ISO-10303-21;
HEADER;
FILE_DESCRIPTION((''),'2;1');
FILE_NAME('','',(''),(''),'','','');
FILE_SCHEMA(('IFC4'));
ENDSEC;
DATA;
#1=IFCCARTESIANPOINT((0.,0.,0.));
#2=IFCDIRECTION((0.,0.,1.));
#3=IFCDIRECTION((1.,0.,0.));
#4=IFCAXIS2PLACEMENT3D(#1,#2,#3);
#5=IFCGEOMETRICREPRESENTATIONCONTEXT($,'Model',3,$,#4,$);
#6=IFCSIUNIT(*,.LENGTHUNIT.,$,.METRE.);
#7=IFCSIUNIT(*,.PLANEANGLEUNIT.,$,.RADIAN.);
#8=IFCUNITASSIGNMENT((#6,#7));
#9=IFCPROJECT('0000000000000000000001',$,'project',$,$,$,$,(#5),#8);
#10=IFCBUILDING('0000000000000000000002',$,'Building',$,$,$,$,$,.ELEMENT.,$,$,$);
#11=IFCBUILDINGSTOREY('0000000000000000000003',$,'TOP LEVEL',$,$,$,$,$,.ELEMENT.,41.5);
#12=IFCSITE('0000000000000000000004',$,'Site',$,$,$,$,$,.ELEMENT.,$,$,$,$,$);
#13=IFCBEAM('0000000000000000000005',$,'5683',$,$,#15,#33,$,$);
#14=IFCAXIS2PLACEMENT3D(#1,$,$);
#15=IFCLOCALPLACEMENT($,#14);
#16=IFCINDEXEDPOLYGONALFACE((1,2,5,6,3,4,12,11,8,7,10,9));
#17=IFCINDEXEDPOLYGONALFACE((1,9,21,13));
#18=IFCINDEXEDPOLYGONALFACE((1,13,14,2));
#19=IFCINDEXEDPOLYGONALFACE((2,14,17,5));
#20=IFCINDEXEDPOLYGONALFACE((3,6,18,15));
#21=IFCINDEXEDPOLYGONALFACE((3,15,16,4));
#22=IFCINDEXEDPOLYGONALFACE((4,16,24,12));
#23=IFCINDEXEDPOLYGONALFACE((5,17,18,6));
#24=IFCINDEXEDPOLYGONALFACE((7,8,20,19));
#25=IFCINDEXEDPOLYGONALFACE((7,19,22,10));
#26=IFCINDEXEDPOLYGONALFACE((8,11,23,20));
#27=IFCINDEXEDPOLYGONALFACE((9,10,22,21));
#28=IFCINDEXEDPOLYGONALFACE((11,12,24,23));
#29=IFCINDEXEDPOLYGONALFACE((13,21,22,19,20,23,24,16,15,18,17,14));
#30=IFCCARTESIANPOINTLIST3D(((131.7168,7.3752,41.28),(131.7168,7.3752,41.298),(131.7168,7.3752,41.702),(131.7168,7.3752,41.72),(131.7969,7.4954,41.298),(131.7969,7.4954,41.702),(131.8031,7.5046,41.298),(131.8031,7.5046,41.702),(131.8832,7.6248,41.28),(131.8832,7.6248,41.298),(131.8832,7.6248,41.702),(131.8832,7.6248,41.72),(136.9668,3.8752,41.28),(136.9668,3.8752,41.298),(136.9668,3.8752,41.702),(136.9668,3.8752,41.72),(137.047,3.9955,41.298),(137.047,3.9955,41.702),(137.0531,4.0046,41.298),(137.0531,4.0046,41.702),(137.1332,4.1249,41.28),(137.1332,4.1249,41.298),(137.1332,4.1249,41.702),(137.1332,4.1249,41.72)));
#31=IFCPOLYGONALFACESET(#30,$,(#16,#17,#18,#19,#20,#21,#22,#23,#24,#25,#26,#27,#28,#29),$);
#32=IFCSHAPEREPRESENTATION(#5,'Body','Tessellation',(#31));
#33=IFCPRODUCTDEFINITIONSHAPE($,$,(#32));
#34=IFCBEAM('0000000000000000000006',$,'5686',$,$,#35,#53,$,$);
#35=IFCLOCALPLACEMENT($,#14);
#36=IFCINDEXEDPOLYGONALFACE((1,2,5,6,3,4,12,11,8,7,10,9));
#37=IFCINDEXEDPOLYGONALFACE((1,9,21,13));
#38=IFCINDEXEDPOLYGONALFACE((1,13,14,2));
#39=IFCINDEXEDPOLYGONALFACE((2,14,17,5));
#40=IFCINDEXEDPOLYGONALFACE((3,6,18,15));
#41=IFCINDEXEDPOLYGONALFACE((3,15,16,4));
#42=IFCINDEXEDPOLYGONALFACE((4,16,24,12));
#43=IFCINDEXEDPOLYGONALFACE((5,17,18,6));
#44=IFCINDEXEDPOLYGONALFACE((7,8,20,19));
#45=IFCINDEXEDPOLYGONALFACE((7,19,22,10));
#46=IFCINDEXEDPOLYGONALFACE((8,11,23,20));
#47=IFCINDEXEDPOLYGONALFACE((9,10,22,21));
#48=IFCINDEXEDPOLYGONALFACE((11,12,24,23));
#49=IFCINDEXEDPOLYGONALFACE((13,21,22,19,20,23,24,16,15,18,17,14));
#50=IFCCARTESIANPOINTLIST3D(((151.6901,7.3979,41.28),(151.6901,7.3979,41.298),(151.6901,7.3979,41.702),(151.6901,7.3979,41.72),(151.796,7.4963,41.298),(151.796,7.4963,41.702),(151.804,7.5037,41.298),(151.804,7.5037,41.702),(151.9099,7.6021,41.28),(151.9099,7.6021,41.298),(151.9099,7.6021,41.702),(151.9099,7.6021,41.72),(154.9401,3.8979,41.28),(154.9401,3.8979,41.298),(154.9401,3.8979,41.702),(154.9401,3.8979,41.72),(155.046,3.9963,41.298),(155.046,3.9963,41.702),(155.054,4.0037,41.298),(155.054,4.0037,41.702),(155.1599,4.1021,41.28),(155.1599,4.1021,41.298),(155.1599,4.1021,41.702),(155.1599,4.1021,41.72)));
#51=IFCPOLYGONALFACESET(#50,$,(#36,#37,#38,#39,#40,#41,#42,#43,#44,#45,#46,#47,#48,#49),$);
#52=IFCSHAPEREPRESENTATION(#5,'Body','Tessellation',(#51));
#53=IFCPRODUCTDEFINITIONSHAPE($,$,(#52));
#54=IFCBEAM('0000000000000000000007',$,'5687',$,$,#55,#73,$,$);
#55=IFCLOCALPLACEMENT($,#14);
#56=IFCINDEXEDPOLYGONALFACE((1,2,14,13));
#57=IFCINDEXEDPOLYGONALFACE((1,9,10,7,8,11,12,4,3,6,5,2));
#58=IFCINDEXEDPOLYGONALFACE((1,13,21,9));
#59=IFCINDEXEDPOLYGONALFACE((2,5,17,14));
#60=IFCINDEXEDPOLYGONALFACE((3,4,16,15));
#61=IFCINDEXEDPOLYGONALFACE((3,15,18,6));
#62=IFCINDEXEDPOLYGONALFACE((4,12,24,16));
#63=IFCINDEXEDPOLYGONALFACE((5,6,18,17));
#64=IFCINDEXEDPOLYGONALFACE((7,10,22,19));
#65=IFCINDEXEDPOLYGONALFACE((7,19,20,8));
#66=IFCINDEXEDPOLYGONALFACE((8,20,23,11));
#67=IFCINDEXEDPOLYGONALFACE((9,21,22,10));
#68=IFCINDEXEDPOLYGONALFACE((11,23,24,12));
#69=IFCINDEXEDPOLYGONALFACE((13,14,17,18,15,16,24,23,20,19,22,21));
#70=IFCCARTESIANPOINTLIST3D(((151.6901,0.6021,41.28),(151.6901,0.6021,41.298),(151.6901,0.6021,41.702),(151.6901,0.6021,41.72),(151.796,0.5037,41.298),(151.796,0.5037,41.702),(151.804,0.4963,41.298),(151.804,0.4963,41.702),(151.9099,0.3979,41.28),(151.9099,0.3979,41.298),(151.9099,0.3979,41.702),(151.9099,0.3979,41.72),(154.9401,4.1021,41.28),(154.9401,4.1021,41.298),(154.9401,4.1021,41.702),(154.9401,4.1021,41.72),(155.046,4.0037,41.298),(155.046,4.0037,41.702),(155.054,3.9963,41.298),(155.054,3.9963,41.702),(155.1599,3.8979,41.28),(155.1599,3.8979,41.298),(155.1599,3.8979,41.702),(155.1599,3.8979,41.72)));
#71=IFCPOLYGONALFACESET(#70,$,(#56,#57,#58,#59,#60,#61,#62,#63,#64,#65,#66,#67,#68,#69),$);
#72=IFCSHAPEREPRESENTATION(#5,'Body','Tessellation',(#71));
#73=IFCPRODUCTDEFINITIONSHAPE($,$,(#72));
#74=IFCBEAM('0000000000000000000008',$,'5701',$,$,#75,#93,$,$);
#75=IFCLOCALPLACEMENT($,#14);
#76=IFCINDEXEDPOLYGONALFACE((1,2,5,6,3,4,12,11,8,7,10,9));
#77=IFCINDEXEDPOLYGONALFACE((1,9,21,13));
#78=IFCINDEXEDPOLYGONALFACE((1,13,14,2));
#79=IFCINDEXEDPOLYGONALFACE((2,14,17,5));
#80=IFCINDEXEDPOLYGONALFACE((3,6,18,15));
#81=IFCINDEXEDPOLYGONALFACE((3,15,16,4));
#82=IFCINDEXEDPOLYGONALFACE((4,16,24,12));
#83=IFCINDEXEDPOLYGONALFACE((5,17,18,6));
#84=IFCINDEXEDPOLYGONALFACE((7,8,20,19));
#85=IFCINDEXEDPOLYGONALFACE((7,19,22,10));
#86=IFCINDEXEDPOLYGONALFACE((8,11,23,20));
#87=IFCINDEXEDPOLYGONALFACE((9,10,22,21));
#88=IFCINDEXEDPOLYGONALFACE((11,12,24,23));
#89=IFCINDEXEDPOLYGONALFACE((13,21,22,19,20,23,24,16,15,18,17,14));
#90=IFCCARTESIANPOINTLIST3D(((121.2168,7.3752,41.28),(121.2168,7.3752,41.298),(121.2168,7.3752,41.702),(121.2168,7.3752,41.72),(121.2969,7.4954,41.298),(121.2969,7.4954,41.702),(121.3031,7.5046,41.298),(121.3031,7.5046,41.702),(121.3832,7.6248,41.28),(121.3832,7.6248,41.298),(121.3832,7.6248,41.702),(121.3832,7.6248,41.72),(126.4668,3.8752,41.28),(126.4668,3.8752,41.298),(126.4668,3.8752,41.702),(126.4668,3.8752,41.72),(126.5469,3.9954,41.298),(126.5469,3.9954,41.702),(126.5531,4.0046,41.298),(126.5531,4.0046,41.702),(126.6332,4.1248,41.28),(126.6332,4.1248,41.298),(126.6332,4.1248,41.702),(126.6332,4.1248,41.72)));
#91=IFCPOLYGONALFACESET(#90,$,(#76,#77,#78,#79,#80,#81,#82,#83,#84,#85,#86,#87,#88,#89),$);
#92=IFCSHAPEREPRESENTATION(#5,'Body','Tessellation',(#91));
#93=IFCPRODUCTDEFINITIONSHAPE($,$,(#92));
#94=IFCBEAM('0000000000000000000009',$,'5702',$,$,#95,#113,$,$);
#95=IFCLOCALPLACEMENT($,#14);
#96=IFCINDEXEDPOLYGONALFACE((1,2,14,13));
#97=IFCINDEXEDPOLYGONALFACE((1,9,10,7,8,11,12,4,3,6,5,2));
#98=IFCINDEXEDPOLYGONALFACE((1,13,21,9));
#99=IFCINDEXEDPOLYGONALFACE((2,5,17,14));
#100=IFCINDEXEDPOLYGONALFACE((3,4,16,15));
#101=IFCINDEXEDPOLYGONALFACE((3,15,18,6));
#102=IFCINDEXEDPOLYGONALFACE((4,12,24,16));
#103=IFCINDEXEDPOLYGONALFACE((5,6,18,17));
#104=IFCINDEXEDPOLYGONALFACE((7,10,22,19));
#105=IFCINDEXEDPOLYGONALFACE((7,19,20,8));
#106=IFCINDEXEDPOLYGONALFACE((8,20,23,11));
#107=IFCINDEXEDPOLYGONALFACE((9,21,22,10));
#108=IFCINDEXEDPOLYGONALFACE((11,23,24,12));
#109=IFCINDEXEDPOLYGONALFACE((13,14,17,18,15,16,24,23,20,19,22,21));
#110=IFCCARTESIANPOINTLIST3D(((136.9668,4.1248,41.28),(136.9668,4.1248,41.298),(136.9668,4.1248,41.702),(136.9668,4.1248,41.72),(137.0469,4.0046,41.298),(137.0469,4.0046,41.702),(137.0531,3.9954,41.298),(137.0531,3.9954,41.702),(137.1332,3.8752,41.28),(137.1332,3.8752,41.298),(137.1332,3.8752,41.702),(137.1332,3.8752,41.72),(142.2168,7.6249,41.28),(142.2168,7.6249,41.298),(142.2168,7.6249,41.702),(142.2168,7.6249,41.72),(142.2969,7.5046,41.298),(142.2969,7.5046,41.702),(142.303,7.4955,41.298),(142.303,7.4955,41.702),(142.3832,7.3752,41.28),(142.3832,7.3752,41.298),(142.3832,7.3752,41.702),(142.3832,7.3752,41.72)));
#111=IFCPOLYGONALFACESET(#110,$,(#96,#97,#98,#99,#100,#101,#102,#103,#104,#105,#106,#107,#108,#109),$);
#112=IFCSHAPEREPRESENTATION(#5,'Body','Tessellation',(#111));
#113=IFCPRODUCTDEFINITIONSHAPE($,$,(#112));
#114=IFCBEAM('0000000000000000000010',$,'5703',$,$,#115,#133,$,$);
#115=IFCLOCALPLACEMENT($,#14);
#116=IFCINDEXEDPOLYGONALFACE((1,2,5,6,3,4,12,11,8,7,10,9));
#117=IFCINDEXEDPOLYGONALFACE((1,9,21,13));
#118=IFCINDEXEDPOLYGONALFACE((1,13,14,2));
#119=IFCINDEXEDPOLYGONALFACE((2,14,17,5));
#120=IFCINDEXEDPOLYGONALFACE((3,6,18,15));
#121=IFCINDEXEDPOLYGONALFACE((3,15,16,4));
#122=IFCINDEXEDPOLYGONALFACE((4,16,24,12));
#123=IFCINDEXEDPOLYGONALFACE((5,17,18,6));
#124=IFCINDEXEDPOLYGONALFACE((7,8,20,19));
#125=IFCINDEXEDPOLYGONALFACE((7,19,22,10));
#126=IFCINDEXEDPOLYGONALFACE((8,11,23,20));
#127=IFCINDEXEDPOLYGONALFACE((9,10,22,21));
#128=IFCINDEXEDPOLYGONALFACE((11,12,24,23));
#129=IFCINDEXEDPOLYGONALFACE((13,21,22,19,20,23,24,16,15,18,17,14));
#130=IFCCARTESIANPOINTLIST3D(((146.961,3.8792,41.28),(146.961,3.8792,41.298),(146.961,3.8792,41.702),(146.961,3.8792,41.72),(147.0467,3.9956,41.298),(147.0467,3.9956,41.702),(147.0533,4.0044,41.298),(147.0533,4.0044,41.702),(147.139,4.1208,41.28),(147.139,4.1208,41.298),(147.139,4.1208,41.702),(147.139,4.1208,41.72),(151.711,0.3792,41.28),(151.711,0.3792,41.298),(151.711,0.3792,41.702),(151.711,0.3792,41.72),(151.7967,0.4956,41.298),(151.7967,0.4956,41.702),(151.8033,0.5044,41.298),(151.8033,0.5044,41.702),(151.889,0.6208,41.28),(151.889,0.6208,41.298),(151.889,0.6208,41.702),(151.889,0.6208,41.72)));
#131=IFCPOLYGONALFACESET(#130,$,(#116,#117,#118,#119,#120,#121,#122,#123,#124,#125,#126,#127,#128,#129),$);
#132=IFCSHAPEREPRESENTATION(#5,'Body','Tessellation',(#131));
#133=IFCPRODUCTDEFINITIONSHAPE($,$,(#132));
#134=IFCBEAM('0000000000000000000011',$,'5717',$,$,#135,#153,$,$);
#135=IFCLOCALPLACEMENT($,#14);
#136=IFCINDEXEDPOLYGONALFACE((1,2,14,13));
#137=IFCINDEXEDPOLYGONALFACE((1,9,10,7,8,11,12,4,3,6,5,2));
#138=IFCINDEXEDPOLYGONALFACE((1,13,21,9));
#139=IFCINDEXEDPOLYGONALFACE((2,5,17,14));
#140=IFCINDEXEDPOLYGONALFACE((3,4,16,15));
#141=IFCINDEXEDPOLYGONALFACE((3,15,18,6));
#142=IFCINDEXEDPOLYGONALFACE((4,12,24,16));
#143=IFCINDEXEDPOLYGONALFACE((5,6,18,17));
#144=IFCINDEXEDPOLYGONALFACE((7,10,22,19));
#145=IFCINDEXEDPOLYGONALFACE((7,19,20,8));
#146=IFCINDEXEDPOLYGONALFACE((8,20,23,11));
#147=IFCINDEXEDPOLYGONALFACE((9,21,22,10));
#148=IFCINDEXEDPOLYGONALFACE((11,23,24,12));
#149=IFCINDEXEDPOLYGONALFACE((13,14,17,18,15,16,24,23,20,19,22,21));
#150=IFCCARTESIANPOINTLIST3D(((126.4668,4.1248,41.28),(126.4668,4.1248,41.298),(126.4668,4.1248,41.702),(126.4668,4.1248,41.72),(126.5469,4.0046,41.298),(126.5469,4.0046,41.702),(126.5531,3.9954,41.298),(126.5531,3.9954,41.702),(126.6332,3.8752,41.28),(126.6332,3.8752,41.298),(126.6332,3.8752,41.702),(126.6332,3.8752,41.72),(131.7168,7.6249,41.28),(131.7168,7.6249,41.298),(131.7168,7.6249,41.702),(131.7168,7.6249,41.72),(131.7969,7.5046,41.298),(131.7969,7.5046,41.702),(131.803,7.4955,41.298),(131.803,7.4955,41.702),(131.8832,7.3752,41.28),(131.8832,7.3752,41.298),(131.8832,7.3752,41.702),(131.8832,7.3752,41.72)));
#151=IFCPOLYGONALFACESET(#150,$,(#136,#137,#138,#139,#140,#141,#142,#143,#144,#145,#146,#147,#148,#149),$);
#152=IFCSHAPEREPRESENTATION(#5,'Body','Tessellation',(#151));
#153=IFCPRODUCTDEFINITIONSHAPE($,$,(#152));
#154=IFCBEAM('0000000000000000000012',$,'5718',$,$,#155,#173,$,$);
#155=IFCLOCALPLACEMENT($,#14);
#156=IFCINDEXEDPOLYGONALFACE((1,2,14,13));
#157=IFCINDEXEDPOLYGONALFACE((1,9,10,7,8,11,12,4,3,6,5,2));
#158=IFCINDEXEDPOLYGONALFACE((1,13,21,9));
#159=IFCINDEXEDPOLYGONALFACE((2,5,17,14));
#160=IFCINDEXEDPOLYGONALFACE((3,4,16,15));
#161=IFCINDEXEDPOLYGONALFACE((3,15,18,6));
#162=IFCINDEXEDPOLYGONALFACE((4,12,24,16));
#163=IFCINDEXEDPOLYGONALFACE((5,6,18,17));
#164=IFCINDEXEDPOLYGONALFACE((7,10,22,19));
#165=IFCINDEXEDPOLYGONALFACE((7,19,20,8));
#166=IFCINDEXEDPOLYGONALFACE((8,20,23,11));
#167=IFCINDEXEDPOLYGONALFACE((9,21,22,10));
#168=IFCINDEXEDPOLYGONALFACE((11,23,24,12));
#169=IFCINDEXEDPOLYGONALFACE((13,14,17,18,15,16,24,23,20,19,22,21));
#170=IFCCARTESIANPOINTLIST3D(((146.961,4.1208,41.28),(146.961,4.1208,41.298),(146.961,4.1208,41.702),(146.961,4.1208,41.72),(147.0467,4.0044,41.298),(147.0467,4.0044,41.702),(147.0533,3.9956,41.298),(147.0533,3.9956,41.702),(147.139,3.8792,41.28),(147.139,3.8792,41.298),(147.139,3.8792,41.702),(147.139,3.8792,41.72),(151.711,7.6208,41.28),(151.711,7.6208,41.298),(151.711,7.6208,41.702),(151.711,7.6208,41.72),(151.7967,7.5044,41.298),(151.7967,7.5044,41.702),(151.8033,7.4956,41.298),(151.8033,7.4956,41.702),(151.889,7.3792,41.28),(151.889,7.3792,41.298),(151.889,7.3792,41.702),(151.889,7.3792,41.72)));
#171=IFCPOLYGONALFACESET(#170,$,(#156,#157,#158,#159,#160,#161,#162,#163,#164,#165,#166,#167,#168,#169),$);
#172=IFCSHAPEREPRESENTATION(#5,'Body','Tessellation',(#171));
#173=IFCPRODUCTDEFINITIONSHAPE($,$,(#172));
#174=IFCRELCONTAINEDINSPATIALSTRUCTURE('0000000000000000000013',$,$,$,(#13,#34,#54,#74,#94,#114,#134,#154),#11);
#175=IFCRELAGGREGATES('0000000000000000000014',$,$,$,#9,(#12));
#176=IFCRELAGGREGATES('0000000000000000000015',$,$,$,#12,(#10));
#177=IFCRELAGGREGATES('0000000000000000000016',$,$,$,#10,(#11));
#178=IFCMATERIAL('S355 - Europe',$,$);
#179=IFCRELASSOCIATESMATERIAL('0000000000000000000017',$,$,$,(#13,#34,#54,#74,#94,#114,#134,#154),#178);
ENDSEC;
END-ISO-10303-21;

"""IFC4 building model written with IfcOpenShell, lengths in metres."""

from ifc_helpers import new_model, si_unit, frame, origin_with_axes, origin_2d_with_axis, place, context, project, spatial, i_section, extrude, material, material_profile, profile_set, profile_usage, element, save


model = new_model("IFC4")

# Units and contexts
model_context = context("Model", 3, world=origin_with_axes())
ifc_project = project(units=[si_unit("LENGTHUNIT", "METRE"), si_unit("PLANEANGLEUNIT", "RADIAN")], contexts=[model_context])

# Site, building, storey
site = spatial("IfcSite", under=ifc_project, Name="Site", CompositionType="ELEMENT")
building = spatial("IfcBuilding", under=site, Name="Building", CompositionType="ELEMENT")
storey = spatial("IfcBuildingStorey", under=building, Name="TOP LEVEL", CompositionType="ELEMENT", Elevation=41.5)

# Beams
ifc_material = material(Name="S355 - Europe")
ifc_material_profile_1 = material_profile(ifc_material, i_section(OverallWidth=0.3, OverallDepth=0.44, WebThickness=0.011, FlangeThickness=0.018, at=origin_2d_with_axis()))
ifc_profile_set_1 = profile_set([ifc_material_profile_1])
ifc_profile_usage_1 = profile_usage(ifc_profile_set_1, cardinal=10)
beam_1_placement = place(None, frame((131.8, 7.5, 41.5), z_axis=(0.832055, -0.554693, 0.0), x_axis=(0.554693, 0.832055, 0.0)))
element("IfcBeam", 1, at=beam_1_placement, inside=storey, material=ifc_profile_usage_1, Name="5683", context=model_context, shape_type="SweptSolid", body=[
    extrude(i_section(OverallWidth=0.3, OverallDepth=0.44, WebThickness=0.011, FlangeThickness=0.018, at=origin_2d_with_axis()), origin_with_axes(), (0.0, 0.0, 1.0), 6.3097),
])
ifc_material_profile_2 = material_profile(ifc_material, i_section(OverallWidth=0.3, OverallDepth=0.44, WebThickness=0.011, FlangeThickness=0.018, at=origin_2d_with_axis()))
ifc_profile_set_2 = profile_set([ifc_material_profile_2])
ifc_profile_usage_2 = profile_usage(ifc_profile_set_2, cardinal=10)
beam_2_placement = place(None, frame((151.8, 7.5, 41.5), z_axis=(0.680451, -0.732793, 0.0), x_axis=(0.732793, 0.680451, 0.0)))
element("IfcBeam", 2, at=beam_2_placement, inside=storey, material=ifc_profile_usage_2, Name="5686", context=model_context, shape_type="SweptSolid", body=[
    extrude(i_section(OverallWidth=0.3, OverallDepth=0.44, WebThickness=0.011, FlangeThickness=0.018, at=origin_2d_with_axis()), origin_with_axes(), (0.0, 0.0, 1.0), 4.7762),
])
ifc_material_profile_3 = material_profile(ifc_material, i_section(OverallWidth=0.3, OverallDepth=0.44, WebThickness=0.011, FlangeThickness=0.018, at=origin_2d_with_axis()))
ifc_profile_set_3 = profile_set([ifc_material_profile_3])
ifc_profile_usage_3 = profile_usage(ifc_profile_set_3, cardinal=10)
beam_3_placement = place(None, frame((151.8, 0.5, 41.5), z_axis=(0.680451, 0.732793, 0.0), x_axis=(-0.732793, 0.680451, 0.0)))
element("IfcBeam", 3, at=beam_3_placement, inside=storey, material=ifc_profile_usage_3, Name="5687", context=model_context, shape_type="SweptSolid", body=[
    extrude(i_section(OverallWidth=0.3, OverallDepth=0.44, WebThickness=0.011, FlangeThickness=0.018, at=origin_2d_with_axis()), origin_with_axes(), (0.0, 0.0, 1.0), 4.7762),
])
ifc_material_profile_4 = material_profile(ifc_material, i_section(OverallWidth=0.3, OverallDepth=0.44, WebThickness=0.011, FlangeThickness=0.018, at=origin_2d_with_axis()))
ifc_profile_set_4 = profile_set([ifc_material_profile_4])
ifc_profile_usage_4 = profile_usage(ifc_profile_set_4, cardinal=10)
beam_4_placement = place(None, frame((126.55, 4.0, 41.5), z_axis=(-0.83205, 0.5547, 0.0), x_axis=(-0.5547, -0.83205, 0.0)))
element("IfcBeam", 4, at=beam_4_placement, inside=storey, material=ifc_profile_usage_4, Name="5701", context=model_context, shape_type="SweptSolid", body=[
    extrude(i_section(OverallWidth=0.3, OverallDepth=0.44, WebThickness=0.011, FlangeThickness=0.018, at=origin_2d_with_axis()), origin_with_axes(), (0.0, 0.0, 1.0), 6.3097),
])
ifc_material_profile_5 = material_profile(ifc_material, i_section(OverallWidth=0.3, OverallDepth=0.44, WebThickness=0.011, FlangeThickness=0.018, at=origin_2d_with_axis()))
ifc_profile_set_5 = profile_set([ifc_material_profile_5])
ifc_profile_usage_5 = profile_usage(ifc_profile_set_5, cardinal=10)
beam_5_placement = place(None, frame((137.05, 4.0, 41.5), z_axis=(0.832045, 0.554708, 0.0), x_axis=(-0.554708, 0.832045, 0.0)))
element("IfcBeam", 5, at=beam_5_placement, inside=storey, material=ifc_profile_usage_5, Name="5702", context=model_context, shape_type="SweptSolid", body=[
    extrude(i_section(OverallWidth=0.3, OverallDepth=0.44, WebThickness=0.011, FlangeThickness=0.018, at=origin_2d_with_axis()), origin_with_axes(), (0.0, 0.0, 1.0), 6.3097),
])
ifc_material_profile_6 = material_profile(ifc_material, i_section(OverallWidth=0.3, OverallDepth=0.44, WebThickness=0.011, FlangeThickness=0.018, at=origin_2d_with_axis()))
ifc_profile_set_6 = profile_set([ifc_material_profile_6])
ifc_profile_usage_6 = profile_usage(ifc_profile_set_6, cardinal=10)
beam_6_placement = place(None, frame((147.05, 4.0, 41.5), z_axis=(0.805056, -0.593199, 0.0), x_axis=(0.593199, 0.805056, 0.0)))
element("IfcBeam", 6, at=beam_6_placement, inside=storey, material=ifc_profile_usage_6, Name="5703", context=model_context, shape_type="SweptSolid", body=[
    extrude(i_section(OverallWidth=0.3, OverallDepth=0.44, WebThickness=0.011, FlangeThickness=0.018, at=origin_2d_with_axis()), origin_with_axes(), (0.0, 0.0, 1.0), 5.9002),
])
ifc_material_profile_7 = material_profile(ifc_material, i_section(OverallWidth=0.3, OverallDepth=0.44, WebThickness=0.011, FlangeThickness=0.018, at=origin_2d_with_axis()))
ifc_profile_set_7 = profile_set([ifc_material_profile_7])
ifc_profile_usage_7 = profile_usage(ifc_profile_set_7, cardinal=10)
beam_7_placement = place(None, frame((126.55, 4.0, 41.5), z_axis=(0.832045, 0.554708, 0.0), x_axis=(-0.554708, 0.832045, 0.0)))
element("IfcBeam", 7, at=beam_7_placement, inside=storey, material=ifc_profile_usage_7, Name="5717", context=model_context, shape_type="SweptSolid", body=[
    extrude(i_section(OverallWidth=0.3, OverallDepth=0.44, WebThickness=0.011, FlangeThickness=0.018, at=origin_2d_with_axis()), origin_with_axes(), (0.0, 0.0, 1.0), 6.3097),
])
ifc_material_profile_8 = material_profile(ifc_material, i_section(OverallWidth=0.3, OverallDepth=0.44, WebThickness=0.011, FlangeThickness=0.018, at=origin_2d_with_axis()))
ifc_profile_set_8 = profile_set([ifc_material_profile_8])
ifc_profile_usage_8 = profile_usage(ifc_profile_set_8, cardinal=10)
beam_8_placement = place(None, frame((147.05, 4.0, 41.5), z_axis=(0.805056, 0.593199, 0.0), x_axis=(-0.593199, 0.805056, 0.0)))
element("IfcBeam", 8, at=beam_8_placement, inside=storey, material=ifc_profile_usage_8, Name="5718", context=model_context, shape_type="SweptSolid", body=[
    extrude(i_section(OverallWidth=0.3, OverallDepth=0.44, WebThickness=0.011, FlangeThickness=0.018, at=origin_2d_with_axis()), origin_with_axes(), (0.0, 0.0, 1.0), 5.9002),
])

save(model, "model.ifc")
